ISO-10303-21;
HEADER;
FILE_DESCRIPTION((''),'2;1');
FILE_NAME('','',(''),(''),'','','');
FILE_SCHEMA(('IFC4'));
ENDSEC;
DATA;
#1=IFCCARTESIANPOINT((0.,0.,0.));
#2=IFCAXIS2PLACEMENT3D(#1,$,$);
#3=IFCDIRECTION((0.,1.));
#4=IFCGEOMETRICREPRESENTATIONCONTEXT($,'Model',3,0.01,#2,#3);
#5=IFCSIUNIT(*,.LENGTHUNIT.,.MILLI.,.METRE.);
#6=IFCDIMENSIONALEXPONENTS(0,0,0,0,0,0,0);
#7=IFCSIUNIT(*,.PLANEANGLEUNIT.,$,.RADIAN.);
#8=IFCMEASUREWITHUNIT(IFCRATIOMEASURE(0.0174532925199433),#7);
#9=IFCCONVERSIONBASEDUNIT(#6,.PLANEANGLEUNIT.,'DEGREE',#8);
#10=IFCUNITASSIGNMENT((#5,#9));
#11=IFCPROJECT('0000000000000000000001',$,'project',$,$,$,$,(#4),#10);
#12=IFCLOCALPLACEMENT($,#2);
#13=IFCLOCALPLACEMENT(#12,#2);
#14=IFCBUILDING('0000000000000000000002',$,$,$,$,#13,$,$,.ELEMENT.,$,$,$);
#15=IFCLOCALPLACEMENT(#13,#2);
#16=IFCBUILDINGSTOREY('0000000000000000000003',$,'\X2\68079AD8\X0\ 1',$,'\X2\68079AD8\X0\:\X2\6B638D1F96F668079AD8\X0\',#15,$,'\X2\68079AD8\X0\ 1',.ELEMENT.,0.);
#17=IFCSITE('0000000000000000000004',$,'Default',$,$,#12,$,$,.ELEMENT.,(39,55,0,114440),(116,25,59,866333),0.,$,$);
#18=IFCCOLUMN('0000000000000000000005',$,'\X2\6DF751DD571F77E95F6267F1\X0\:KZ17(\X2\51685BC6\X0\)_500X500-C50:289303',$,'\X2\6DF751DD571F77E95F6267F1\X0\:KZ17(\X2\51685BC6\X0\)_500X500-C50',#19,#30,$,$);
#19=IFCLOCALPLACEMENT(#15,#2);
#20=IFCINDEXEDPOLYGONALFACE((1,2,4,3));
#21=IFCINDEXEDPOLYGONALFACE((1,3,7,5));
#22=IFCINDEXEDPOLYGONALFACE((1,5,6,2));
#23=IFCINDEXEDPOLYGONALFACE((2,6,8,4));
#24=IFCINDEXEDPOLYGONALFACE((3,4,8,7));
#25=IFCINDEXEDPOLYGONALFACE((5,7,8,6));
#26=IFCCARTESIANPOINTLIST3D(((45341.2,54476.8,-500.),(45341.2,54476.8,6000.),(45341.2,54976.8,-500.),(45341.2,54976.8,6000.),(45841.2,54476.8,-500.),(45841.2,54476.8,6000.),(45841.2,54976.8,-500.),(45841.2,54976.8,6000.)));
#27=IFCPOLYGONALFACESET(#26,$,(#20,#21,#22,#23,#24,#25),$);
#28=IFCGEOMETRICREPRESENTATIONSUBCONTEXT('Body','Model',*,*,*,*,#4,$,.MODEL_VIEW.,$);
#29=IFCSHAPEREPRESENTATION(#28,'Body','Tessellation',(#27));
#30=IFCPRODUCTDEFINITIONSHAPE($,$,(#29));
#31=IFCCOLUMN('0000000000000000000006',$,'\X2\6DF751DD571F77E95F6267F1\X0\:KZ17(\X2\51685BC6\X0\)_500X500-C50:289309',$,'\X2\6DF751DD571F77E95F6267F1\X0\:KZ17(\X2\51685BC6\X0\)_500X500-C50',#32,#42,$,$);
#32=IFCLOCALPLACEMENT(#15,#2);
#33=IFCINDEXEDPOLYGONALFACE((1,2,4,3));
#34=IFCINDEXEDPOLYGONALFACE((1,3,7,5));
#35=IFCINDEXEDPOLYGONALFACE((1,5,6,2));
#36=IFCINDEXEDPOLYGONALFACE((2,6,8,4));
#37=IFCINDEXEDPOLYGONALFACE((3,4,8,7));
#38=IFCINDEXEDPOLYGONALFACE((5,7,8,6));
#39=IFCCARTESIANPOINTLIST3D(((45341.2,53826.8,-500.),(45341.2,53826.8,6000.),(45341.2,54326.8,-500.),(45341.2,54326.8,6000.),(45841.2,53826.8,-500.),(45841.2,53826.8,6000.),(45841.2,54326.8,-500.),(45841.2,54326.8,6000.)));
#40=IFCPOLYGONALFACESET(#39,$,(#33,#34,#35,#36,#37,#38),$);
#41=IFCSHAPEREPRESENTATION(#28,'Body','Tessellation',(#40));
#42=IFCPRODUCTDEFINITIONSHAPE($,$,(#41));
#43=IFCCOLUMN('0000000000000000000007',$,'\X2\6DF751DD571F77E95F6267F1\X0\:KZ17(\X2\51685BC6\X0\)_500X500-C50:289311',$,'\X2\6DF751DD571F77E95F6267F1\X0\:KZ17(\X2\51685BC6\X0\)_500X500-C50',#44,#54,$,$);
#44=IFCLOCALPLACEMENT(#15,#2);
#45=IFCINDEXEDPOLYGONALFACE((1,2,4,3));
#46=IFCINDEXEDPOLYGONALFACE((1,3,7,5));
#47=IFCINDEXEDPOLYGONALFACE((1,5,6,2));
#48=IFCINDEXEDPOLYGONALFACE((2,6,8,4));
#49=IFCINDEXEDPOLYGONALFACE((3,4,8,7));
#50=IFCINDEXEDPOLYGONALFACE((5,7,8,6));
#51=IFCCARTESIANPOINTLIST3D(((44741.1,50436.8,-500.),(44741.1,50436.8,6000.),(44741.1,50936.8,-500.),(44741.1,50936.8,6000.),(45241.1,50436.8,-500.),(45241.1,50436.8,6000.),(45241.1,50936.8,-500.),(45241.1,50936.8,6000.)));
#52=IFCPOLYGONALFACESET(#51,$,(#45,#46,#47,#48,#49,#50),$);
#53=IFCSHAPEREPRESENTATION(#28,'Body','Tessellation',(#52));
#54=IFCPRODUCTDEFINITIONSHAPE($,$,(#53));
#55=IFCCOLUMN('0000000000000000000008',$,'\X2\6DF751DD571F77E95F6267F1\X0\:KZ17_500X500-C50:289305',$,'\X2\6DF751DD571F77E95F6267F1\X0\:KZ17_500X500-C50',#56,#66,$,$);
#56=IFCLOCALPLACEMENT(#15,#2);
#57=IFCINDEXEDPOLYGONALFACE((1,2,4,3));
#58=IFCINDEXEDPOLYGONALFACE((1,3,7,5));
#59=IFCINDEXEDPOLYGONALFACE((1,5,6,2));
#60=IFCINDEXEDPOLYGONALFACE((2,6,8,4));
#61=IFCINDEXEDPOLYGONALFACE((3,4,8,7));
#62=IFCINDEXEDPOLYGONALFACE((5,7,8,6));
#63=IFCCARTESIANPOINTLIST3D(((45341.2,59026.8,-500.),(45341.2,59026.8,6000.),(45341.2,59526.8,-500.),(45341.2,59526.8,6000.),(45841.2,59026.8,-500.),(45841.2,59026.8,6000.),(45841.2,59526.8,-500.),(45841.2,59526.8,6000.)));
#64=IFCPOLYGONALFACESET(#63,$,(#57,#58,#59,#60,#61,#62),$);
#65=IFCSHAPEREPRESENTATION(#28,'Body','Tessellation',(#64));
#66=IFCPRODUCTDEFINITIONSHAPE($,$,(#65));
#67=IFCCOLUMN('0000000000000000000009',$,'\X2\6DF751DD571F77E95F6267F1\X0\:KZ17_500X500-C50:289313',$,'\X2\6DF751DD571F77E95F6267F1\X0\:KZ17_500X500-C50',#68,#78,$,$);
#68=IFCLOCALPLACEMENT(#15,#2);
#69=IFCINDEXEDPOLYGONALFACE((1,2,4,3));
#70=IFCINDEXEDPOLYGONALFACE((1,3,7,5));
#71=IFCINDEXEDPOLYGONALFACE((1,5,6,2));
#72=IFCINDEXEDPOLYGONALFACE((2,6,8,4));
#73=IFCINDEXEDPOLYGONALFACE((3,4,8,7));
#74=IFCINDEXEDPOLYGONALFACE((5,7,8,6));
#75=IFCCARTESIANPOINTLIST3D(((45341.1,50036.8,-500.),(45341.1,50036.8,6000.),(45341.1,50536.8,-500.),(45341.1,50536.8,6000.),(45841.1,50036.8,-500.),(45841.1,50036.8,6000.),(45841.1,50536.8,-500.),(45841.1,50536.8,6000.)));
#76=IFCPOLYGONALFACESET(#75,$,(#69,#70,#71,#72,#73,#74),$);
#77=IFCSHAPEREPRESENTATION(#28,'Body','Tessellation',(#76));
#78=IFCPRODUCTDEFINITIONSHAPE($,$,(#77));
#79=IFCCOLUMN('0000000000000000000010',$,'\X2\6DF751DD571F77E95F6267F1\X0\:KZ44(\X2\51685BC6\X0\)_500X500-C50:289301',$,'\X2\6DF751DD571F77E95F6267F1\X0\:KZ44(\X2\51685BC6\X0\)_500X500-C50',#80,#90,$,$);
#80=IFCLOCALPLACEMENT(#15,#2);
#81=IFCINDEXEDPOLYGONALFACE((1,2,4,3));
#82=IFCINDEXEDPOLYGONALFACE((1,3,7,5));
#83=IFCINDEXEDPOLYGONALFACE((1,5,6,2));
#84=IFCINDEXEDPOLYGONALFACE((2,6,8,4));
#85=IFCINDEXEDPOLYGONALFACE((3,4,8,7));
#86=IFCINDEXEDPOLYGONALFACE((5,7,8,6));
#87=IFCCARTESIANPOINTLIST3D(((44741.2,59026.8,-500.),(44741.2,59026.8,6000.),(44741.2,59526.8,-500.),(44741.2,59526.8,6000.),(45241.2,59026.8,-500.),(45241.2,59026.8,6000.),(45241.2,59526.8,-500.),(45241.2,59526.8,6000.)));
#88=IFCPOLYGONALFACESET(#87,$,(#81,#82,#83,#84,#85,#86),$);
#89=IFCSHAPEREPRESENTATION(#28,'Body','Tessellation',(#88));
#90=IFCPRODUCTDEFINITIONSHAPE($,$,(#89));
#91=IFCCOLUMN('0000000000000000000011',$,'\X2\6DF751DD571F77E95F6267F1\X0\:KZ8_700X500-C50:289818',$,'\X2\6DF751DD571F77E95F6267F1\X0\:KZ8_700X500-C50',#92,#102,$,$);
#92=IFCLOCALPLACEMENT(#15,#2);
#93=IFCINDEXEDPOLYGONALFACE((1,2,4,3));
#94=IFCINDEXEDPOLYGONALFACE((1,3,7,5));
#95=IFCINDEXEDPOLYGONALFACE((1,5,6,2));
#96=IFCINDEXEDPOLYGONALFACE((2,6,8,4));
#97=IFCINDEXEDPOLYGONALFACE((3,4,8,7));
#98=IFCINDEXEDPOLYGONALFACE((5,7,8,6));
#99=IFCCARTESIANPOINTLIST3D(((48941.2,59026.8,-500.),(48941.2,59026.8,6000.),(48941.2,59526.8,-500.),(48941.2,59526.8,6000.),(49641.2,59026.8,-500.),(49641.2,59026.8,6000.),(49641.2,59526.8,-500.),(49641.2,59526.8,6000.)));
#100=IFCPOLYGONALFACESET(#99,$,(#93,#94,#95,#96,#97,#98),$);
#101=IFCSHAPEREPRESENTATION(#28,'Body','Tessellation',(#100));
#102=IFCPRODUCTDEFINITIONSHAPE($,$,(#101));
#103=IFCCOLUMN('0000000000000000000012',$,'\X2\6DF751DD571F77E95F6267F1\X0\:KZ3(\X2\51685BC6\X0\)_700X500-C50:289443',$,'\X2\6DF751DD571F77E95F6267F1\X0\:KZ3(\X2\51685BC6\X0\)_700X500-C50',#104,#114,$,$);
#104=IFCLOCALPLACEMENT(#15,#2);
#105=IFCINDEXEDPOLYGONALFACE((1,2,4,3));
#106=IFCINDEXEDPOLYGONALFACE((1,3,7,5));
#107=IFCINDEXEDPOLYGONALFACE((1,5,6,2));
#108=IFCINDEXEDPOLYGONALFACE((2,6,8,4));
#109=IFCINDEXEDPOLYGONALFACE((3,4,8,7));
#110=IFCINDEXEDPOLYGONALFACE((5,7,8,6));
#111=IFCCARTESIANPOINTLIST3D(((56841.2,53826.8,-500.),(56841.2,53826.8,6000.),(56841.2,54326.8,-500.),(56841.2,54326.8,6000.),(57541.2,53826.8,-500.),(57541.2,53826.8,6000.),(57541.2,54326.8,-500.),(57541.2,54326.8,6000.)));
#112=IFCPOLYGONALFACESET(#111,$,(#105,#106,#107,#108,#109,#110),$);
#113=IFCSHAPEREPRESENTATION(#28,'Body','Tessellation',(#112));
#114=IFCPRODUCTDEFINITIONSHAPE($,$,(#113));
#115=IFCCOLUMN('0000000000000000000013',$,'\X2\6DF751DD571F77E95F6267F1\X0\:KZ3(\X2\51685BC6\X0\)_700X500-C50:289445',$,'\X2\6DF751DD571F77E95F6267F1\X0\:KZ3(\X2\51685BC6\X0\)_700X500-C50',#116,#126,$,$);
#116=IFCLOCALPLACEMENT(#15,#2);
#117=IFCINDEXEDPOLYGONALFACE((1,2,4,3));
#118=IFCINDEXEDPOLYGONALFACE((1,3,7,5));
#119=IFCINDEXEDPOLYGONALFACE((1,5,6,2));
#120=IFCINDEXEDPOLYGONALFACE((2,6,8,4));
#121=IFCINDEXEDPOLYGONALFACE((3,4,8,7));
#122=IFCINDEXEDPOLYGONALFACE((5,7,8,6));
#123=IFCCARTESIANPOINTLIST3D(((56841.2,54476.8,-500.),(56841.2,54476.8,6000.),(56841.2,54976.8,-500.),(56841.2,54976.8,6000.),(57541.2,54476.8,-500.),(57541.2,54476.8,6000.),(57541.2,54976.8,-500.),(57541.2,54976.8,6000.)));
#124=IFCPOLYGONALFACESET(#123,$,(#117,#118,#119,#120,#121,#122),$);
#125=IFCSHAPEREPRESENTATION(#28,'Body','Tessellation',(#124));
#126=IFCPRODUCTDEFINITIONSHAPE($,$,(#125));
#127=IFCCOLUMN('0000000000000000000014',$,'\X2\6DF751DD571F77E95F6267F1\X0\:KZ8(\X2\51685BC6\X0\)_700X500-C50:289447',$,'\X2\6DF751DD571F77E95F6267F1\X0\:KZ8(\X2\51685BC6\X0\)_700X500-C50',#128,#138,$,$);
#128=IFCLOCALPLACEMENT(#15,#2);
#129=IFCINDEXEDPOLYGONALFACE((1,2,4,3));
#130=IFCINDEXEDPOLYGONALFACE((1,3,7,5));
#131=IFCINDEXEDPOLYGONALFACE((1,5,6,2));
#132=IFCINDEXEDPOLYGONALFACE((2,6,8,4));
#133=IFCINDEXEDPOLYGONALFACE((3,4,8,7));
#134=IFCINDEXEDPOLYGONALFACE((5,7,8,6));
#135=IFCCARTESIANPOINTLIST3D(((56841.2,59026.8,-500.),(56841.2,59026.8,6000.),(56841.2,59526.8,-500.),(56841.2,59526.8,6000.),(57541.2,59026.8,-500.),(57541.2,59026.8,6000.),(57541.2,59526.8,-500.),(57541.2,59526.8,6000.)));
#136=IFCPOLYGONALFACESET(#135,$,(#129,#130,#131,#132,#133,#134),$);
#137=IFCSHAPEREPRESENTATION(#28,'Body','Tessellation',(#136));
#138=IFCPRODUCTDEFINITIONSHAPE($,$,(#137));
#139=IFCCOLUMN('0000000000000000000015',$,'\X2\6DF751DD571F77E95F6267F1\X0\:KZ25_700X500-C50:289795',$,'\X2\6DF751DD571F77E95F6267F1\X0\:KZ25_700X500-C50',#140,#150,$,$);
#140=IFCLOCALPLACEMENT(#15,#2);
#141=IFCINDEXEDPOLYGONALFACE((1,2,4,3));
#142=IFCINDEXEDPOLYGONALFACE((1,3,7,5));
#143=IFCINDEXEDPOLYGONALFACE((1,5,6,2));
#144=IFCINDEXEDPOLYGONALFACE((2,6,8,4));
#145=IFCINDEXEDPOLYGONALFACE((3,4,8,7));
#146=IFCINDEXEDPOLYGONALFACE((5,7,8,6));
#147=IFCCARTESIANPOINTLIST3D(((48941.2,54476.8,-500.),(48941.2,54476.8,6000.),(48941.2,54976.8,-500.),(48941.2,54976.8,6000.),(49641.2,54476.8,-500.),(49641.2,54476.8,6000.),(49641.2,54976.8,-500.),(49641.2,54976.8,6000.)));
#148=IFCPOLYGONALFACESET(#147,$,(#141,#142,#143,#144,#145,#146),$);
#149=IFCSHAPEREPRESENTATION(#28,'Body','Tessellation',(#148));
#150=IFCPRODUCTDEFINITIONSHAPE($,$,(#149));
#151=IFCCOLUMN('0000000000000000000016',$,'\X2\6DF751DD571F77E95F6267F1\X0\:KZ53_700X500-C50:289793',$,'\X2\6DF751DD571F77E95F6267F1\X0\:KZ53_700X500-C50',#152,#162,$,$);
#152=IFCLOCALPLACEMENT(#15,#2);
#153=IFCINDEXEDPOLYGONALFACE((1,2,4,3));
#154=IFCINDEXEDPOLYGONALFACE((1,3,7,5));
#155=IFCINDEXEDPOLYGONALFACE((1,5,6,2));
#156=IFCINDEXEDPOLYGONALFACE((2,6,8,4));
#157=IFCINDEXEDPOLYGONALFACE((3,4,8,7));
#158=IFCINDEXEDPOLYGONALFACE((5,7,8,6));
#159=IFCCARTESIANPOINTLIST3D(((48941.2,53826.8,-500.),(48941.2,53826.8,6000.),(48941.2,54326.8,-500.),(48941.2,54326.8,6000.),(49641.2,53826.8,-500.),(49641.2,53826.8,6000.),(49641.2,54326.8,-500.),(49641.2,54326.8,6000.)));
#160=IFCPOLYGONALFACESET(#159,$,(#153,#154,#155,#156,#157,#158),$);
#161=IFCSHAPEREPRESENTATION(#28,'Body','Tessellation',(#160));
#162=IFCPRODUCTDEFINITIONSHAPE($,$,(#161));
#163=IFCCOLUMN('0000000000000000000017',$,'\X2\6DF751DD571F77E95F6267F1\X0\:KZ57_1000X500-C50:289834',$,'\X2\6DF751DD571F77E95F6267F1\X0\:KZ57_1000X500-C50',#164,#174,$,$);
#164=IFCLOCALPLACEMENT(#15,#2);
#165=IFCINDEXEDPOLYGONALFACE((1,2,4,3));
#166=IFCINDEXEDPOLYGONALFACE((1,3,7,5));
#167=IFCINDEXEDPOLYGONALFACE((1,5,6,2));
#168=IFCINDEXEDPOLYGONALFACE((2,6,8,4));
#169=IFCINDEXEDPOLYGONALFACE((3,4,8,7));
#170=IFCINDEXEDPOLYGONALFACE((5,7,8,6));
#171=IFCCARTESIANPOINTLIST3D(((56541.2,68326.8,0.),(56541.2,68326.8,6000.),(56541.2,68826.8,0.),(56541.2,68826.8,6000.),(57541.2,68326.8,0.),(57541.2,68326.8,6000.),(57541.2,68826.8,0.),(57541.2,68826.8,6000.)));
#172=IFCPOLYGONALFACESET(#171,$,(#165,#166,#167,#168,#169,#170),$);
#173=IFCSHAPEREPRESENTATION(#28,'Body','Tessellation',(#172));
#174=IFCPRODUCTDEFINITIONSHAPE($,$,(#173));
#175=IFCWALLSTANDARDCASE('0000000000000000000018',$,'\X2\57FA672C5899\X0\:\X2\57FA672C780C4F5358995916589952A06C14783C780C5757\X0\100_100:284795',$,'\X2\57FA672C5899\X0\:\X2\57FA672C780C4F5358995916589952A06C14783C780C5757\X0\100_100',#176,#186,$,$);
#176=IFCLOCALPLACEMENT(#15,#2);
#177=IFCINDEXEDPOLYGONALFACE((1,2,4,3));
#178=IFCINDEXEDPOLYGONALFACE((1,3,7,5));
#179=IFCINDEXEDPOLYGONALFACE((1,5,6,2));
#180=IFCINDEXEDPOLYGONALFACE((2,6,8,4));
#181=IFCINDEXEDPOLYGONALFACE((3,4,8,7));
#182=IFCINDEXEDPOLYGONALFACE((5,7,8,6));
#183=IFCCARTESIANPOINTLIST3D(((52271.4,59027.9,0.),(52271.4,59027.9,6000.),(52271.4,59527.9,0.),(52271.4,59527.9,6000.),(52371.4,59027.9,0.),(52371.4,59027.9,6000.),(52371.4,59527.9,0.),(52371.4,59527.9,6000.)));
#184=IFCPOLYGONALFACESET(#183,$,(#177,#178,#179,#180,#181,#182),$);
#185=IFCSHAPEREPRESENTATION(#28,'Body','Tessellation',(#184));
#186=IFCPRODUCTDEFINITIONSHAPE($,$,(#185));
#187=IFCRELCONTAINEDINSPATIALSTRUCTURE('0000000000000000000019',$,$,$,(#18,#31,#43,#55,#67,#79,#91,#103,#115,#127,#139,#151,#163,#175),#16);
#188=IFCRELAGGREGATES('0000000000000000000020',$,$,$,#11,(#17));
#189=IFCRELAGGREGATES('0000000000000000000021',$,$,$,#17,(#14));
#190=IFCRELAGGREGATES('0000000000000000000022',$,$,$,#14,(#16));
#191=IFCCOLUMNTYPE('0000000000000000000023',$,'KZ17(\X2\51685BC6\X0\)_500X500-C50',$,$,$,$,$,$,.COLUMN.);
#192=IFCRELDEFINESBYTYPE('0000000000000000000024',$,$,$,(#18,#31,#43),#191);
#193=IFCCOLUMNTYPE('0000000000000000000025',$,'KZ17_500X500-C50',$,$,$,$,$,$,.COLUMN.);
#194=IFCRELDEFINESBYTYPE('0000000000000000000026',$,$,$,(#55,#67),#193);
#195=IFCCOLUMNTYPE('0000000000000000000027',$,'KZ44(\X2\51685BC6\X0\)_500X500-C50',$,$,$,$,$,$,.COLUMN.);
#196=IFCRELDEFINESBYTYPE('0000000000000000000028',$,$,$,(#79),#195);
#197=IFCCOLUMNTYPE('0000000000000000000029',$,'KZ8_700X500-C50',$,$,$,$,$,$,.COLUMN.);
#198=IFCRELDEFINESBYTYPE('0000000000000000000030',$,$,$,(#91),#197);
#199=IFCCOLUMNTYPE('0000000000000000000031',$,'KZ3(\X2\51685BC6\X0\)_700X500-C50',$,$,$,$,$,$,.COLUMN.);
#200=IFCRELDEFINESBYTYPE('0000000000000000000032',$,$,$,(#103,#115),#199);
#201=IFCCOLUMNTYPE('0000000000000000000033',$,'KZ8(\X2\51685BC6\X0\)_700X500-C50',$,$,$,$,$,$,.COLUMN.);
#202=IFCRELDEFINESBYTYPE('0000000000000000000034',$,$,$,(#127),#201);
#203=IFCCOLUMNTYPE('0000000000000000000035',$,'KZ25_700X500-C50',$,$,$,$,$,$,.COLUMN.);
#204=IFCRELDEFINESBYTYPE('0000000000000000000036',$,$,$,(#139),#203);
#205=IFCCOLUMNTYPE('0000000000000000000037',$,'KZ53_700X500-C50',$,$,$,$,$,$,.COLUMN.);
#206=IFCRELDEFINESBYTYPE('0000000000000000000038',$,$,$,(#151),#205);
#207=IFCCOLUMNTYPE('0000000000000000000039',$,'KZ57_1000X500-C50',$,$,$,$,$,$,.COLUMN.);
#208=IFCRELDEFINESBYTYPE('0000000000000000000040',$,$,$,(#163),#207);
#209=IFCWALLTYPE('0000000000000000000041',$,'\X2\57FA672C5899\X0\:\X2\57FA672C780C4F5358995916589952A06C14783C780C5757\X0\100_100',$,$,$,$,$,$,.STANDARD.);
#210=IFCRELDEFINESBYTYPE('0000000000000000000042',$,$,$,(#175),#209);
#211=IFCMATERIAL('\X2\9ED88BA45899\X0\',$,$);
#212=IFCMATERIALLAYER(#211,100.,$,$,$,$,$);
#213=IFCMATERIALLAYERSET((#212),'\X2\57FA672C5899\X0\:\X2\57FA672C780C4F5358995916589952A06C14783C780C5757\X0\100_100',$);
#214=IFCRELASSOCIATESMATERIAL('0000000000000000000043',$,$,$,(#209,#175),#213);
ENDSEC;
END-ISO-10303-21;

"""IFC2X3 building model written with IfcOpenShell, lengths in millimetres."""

from ifc_helpers import new_model, entity, si_unit, converted_unit, direction, frame, frame_2d, origin, origin_2d_with_axis, place, context, subcontext, project, spatial, rectangle, extrude, source, transform, mapped, material, layer, layer_set, layer_usage, type_object, type_shapes, element, save


model = new_model("IFC2X3")

# Units and contexts
model_context = context("Model", 3, precision=0.01, world=origin(), true_north=direction((0.0, 1.0)))
body_context = subcontext(model_context, "Body", "Model", "MODEL_VIEW")
ifc_project = project(units=[si_unit("LENGTHUNIT", "METRE", prefix="MILLI"), converted_unit("PLANEANGLEUNIT", "DEGREE", entity("IfcRatioMeasure", 0.0174532925199433), si_unit("PLANEANGLEUNIT", "RADIAN"), dimensions=[0, 0, 0, 0, 0, 0, 0])], contexts=[model_context])

# Site, building, storey
site_placement = place(None, origin())
site = spatial("IfcSite", under=ifc_project, at=site_placement, Name="Default", CompositionType="ELEMENT", RefLatitude=(39, 55, 0, 114440), RefLongitude=(116, 25, 59, 866333), RefElevation=0.0)
building_placement = place(site_placement, origin())
building = spatial("IfcBuilding", under=site, at=building_placement, CompositionType="ELEMENT")
storey_placement = place(building_placement, origin())
storey = spatial("IfcBuildingStorey", under=building, at=storey_placement, Name="标高 1", ObjectType="标高:正负零标高", LongName="标高 1", CompositionType="ELEMENT", Elevation=0.0)

# Columns
column_type_1 = type_object("IfcColumnType", Name="KZ17(全密)_500X500-C50", PredefinedType="COLUMN")
shared_shape_1 = source(origin(), body_context, "Body", "SweptSolid", [
    extrude(rectangle(XDim=500.0, YDim=500.0, at=origin_2d_with_axis()), frame((0.0, 0.0, -500.0), z_axis=(0.0, 0.0, 1.0), x_axis=(0.0, -1.0, 0.0)), (0.0, 0.0, 1.0), 6500.0),
])
type_shapes(column_type_1, [shared_shape_1])
for number, where, name in (
    (1, (45591.2, 54726.8, 0.0), "混凝土矩形柱:KZ17(全密)_500X500-C50:289303"),
    (2, (45591.2, 54076.8, 0.0), "混凝土矩形柱:KZ17(全密)_500X500-C50:289309"),
    (3, (44991.1, 50686.8, 0.0), "混凝土矩形柱:KZ17(全密)_500X500-C50:289311"),
):
    element("IfcColumn", number, at=place(building_placement, frame(where)), inside=storey, type_object=column_type_1, Name=name, ObjectType="混凝土矩形柱:KZ17(全密)_500X500-C50", context=body_context, shape_type="MappedRepresentation", body=[
        mapped(shared_shape_1, transform((0.0, 0.0, 0.0), scale=1.0)),
    ])
column_type_2 = type_object("IfcColumnType", Name="KZ17_500X500-C50", PredefinedType="COLUMN")
shared_shape_2 = source(origin(), body_context, "Body", "SweptSolid", [
    extrude(rectangle(XDim=500.0, YDim=500.0, at=origin_2d_with_axis()), frame((0.0, 0.0, -500.0), z_axis=(0.0, 0.0, 1.0), x_axis=(0.0, -1.0, 0.0)), (0.0, 0.0, 1.0), 6500.0),
])
type_shapes(column_type_2, [shared_shape_2])
for number, where, name in (
    (4, (45591.2, 59276.8, 0.0), "混凝土矩形柱:KZ17_500X500-C50:289305"),
    (5, (45591.1, 50286.8, 0.0), "混凝土矩形柱:KZ17_500X500-C50:289313"),
):
    element("IfcColumn", number, at=place(building_placement, frame(where)), inside=storey, type_object=column_type_2, Name=name, ObjectType="混凝土矩形柱:KZ17_500X500-C50", context=body_context, shape_type="MappedRepresentation", body=[
        mapped(shared_shape_2, transform((0.0, 0.0, 0.0), scale=1.0)),
    ])
column_type_3 = type_object("IfcColumnType", Name="KZ44(全密)_500X500-C50", PredefinedType="COLUMN")
shared_shape_3 = source(origin(), body_context, "Body", "SweptSolid", [
    extrude(rectangle(XDim=500.0, YDim=500.0, at=origin_2d_with_axis()), frame((0.0, 0.0, -500.0), z_axis=(0.0, 0.0, 1.0), x_axis=(0.0, -1.0, 0.0)), (0.0, 0.0, 1.0), 6500.0),
])
type_shapes(column_type_3, [shared_shape_3])
column_1_placement = place(building_placement, frame((44991.2, 59276.8, 0.0)))
element("IfcColumn", 6, at=column_1_placement, inside=storey, type_object=column_type_3, Name="混凝土矩形柱:KZ44(全密)_500X500-C50:289301", ObjectType="混凝土矩形柱:KZ44(全密)_500X500-C50", context=body_context, shape_type="MappedRepresentation", body=[
    mapped(shared_shape_3, transform((0.0, 0.0, 0.0), scale=1.0)),
])
column_type_4 = type_object("IfcColumnType", Name="KZ8_700X500-C50", PredefinedType="COLUMN")
shared_shape_4 = source(origin(), body_context, "Body", "SweptSolid", [
    extrude(rectangle(XDim=500.0, YDim=700.0, at=origin_2d_with_axis()), frame((0.0, 0.0, -500.0), z_axis=(0.0, 0.0, 1.0), x_axis=(0.0, -1.0, 0.0)), (0.0, 0.0, 1.0), 6500.0),
])
type_shapes(column_type_4, [shared_shape_4])
column_2_placement = place(building_placement, frame((49291.2, 59276.8, 0.0)))
element("IfcColumn", 7, at=column_2_placement, inside=storey, type_object=column_type_4, Name="混凝土矩形柱:KZ8_700X500-C50:289818", ObjectType="混凝土矩形柱:KZ8_700X500-C50", context=body_context, shape_type="MappedRepresentation", body=[
    mapped(shared_shape_4, transform((0.0, 0.0, 0.0), scale=1.0)),
])
column_type_5 = type_object("IfcColumnType", Name="KZ3(全密)_700X500-C50", PredefinedType="COLUMN")
shared_shape_5 = source(origin(), body_context, "Body", "SweptSolid", [
    extrude(rectangle(XDim=500.0, YDim=700.0, at=origin_2d_with_axis()), frame((0.0, 0.0, -500.0), z_axis=(0.0, 0.0, 1.0), x_axis=(0.0, -1.0, 0.0)), (0.0, 0.0, 1.0), 6500.0),
])
type_shapes(column_type_5, [shared_shape_5])
for number, where, name in (
    (8, (57191.2, 54076.8, 0.0), "混凝土矩形柱:KZ3(全密)_700X500-C50:289443"),
    (9, (57191.2, 54726.8, 0.0), "混凝土矩形柱:KZ3(全密)_700X500-C50:289445"),
):
    element("IfcColumn", number, at=place(building_placement, frame(where)), inside=storey, type_object=column_type_5, Name=name, ObjectType="混凝土矩形柱:KZ3(全密)_700X500-C50", context=body_context, shape_type="MappedRepresentation", body=[
        mapped(shared_shape_5, transform((0.0, 0.0, 0.0), scale=1.0)),
    ])
column_type_6 = type_object("IfcColumnType", Name="KZ8(全密)_700X500-C50", PredefinedType="COLUMN")
shared_shape_6 = source(origin(), body_context, "Body", "SweptSolid", [
    extrude(rectangle(XDim=500.0, YDim=700.0, at=origin_2d_with_axis()), frame((0.0, 0.0, -500.0), z_axis=(0.0, 0.0, 1.0), x_axis=(0.0, -1.0, 0.0)), (0.0, 0.0, 1.0), 6500.0),
])
type_shapes(column_type_6, [shared_shape_6])
column_3_placement = place(building_placement, frame((57191.2, 59276.8, 0.0)))
element("IfcColumn", 10, at=column_3_placement, inside=storey, type_object=column_type_6, Name="混凝土矩形柱:KZ8(全密)_700X500-C50:289447", ObjectType="混凝土矩形柱:KZ8(全密)_700X500-C50", context=body_context, shape_type="MappedRepresentation", body=[
    mapped(shared_shape_6, transform((0.0, 0.0, 0.0), scale=1.0)),
])
column_type_7 = type_object("IfcColumnType", Name="KZ25_700X500-C50", PredefinedType="COLUMN")
shared_shape_7 = source(origin(), body_context, "Body", "SweptSolid", [
    extrude(rectangle(XDim=500.0, YDim=700.0, at=origin_2d_with_axis()), frame((0.0, 0.0, -500.0), z_axis=(0.0, 0.0, 1.0), x_axis=(0.0, -1.0, 0.0)), (0.0, 0.0, 1.0), 6500.0),
])
type_shapes(column_type_7, [shared_shape_7])
column_4_placement = place(building_placement, frame((49291.2, 54726.8, 0.0)))
element("IfcColumn", 11, at=column_4_placement, inside=storey, type_object=column_type_7, Name="混凝土矩形柱:KZ25_700X500-C50:289795", ObjectType="混凝土矩形柱:KZ25_700X500-C50", context=body_context, shape_type="MappedRepresentation", body=[
    mapped(shared_shape_7, transform((0.0, 0.0, 0.0), scale=1.0)),
])
column_type_8 = type_object("IfcColumnType", Name="KZ53_700X500-C50", PredefinedType="COLUMN")
shared_shape_8 = source(origin(), body_context, "Body", "SweptSolid", [
    extrude(rectangle(XDim=500.0, YDim=700.0, at=origin_2d_with_axis()), frame((0.0, 0.0, -500.0), z_axis=(0.0, 0.0, 1.0), x_axis=(0.0, -1.0, 0.0)), (0.0, 0.0, 1.0), 6500.0),
])
type_shapes(column_type_8, [shared_shape_8])
column_5_placement = place(building_placement, frame((49291.2, 54076.8, 0.0)))
element("IfcColumn", 12, at=column_5_placement, inside=storey, type_object=column_type_8, Name="混凝土矩形柱:KZ53_700X500-C50:289793", ObjectType="混凝土矩形柱:KZ53_700X500-C50", context=body_context, shape_type="MappedRepresentation", body=[
    mapped(shared_shape_8, transform((0.0, 0.0, 0.0), scale=1.0)),
])
column_type_9 = type_object("IfcColumnType", Name="KZ57_1000X500-C50", PredefinedType="COLUMN")
shared_shape_9 = source(origin(), body_context, "Body", "SweptSolid", [
    extrude(rectangle(XDim=500.0, YDim=1000.0, at=origin_2d_with_axis()), frame((0.0, 0.0, 0.0), z_axis=(0.0, 0.0, 1.0), x_axis=(0.0, -1.0, 0.0)), (0.0, 0.0, 1.0), 6000.0),
])
type_shapes(column_type_9, [shared_shape_9])
column_6_placement = place(building_placement, frame((57041.2, 68576.8, 0.0)))
element("IfcColumn", 13, at=column_6_placement, inside=storey, type_object=column_type_9, Name="混凝土矩形柱:KZ57_1000X500-C50:289834", ObjectType="混凝土矩形柱:KZ57_1000X500-C50", context=body_context, shape_type="MappedRepresentation", body=[
    mapped(shared_shape_9, transform((0.0, 0.0, 0.0), scale=1.0)),
])

# Wall
ifc_material = material(Name="默认墙")
ifc_layer_1 = layer(ifc_material, 100.0)
ifc_layer_set_1 = layer_set([ifc_layer_1], Name="基本墙:基本砌体墙外墙加气砼砌块100_100")
ifc_layer_usage_1 = layer_usage(ifc_layer_set_1, "AXIS2", "NEGATIVE", 50.0)
wall_type_1 = type_object("IfcWallType", Name="基本墙:基本砌体墙外墙加气砼砌块100_100", PredefinedType="STANDARD", material=ifc_layer_set_1)
wall_1_placement = place(building_placement, frame((52321.4, 59027.9, 0.0), z_axis=(0.0, 0.0, 1.0), x_axis=(0.0, 1.0, 0.0)))
element("IfcWallStandardCase", 14, at=wall_1_placement, inside=storey, type_object=wall_type_1, material=ifc_layer_usage_1, Name="基本墙:基本砌体墙外墙加气砼砌块100_100:284795", ObjectType="基本墙:基本砌体墙外墙加气砼砌块100_100", context=body_context, shape_type="SweptSolid", body=[
    extrude(rectangle(XDim=500.0, YDim=100.0, at=frame_2d((250.0, 0.0), x_axis=(-1.0, 0.0))), origin(), (0.0, 0.0, 1.0), 6000.0),
])

save(model, "model.ifc")
